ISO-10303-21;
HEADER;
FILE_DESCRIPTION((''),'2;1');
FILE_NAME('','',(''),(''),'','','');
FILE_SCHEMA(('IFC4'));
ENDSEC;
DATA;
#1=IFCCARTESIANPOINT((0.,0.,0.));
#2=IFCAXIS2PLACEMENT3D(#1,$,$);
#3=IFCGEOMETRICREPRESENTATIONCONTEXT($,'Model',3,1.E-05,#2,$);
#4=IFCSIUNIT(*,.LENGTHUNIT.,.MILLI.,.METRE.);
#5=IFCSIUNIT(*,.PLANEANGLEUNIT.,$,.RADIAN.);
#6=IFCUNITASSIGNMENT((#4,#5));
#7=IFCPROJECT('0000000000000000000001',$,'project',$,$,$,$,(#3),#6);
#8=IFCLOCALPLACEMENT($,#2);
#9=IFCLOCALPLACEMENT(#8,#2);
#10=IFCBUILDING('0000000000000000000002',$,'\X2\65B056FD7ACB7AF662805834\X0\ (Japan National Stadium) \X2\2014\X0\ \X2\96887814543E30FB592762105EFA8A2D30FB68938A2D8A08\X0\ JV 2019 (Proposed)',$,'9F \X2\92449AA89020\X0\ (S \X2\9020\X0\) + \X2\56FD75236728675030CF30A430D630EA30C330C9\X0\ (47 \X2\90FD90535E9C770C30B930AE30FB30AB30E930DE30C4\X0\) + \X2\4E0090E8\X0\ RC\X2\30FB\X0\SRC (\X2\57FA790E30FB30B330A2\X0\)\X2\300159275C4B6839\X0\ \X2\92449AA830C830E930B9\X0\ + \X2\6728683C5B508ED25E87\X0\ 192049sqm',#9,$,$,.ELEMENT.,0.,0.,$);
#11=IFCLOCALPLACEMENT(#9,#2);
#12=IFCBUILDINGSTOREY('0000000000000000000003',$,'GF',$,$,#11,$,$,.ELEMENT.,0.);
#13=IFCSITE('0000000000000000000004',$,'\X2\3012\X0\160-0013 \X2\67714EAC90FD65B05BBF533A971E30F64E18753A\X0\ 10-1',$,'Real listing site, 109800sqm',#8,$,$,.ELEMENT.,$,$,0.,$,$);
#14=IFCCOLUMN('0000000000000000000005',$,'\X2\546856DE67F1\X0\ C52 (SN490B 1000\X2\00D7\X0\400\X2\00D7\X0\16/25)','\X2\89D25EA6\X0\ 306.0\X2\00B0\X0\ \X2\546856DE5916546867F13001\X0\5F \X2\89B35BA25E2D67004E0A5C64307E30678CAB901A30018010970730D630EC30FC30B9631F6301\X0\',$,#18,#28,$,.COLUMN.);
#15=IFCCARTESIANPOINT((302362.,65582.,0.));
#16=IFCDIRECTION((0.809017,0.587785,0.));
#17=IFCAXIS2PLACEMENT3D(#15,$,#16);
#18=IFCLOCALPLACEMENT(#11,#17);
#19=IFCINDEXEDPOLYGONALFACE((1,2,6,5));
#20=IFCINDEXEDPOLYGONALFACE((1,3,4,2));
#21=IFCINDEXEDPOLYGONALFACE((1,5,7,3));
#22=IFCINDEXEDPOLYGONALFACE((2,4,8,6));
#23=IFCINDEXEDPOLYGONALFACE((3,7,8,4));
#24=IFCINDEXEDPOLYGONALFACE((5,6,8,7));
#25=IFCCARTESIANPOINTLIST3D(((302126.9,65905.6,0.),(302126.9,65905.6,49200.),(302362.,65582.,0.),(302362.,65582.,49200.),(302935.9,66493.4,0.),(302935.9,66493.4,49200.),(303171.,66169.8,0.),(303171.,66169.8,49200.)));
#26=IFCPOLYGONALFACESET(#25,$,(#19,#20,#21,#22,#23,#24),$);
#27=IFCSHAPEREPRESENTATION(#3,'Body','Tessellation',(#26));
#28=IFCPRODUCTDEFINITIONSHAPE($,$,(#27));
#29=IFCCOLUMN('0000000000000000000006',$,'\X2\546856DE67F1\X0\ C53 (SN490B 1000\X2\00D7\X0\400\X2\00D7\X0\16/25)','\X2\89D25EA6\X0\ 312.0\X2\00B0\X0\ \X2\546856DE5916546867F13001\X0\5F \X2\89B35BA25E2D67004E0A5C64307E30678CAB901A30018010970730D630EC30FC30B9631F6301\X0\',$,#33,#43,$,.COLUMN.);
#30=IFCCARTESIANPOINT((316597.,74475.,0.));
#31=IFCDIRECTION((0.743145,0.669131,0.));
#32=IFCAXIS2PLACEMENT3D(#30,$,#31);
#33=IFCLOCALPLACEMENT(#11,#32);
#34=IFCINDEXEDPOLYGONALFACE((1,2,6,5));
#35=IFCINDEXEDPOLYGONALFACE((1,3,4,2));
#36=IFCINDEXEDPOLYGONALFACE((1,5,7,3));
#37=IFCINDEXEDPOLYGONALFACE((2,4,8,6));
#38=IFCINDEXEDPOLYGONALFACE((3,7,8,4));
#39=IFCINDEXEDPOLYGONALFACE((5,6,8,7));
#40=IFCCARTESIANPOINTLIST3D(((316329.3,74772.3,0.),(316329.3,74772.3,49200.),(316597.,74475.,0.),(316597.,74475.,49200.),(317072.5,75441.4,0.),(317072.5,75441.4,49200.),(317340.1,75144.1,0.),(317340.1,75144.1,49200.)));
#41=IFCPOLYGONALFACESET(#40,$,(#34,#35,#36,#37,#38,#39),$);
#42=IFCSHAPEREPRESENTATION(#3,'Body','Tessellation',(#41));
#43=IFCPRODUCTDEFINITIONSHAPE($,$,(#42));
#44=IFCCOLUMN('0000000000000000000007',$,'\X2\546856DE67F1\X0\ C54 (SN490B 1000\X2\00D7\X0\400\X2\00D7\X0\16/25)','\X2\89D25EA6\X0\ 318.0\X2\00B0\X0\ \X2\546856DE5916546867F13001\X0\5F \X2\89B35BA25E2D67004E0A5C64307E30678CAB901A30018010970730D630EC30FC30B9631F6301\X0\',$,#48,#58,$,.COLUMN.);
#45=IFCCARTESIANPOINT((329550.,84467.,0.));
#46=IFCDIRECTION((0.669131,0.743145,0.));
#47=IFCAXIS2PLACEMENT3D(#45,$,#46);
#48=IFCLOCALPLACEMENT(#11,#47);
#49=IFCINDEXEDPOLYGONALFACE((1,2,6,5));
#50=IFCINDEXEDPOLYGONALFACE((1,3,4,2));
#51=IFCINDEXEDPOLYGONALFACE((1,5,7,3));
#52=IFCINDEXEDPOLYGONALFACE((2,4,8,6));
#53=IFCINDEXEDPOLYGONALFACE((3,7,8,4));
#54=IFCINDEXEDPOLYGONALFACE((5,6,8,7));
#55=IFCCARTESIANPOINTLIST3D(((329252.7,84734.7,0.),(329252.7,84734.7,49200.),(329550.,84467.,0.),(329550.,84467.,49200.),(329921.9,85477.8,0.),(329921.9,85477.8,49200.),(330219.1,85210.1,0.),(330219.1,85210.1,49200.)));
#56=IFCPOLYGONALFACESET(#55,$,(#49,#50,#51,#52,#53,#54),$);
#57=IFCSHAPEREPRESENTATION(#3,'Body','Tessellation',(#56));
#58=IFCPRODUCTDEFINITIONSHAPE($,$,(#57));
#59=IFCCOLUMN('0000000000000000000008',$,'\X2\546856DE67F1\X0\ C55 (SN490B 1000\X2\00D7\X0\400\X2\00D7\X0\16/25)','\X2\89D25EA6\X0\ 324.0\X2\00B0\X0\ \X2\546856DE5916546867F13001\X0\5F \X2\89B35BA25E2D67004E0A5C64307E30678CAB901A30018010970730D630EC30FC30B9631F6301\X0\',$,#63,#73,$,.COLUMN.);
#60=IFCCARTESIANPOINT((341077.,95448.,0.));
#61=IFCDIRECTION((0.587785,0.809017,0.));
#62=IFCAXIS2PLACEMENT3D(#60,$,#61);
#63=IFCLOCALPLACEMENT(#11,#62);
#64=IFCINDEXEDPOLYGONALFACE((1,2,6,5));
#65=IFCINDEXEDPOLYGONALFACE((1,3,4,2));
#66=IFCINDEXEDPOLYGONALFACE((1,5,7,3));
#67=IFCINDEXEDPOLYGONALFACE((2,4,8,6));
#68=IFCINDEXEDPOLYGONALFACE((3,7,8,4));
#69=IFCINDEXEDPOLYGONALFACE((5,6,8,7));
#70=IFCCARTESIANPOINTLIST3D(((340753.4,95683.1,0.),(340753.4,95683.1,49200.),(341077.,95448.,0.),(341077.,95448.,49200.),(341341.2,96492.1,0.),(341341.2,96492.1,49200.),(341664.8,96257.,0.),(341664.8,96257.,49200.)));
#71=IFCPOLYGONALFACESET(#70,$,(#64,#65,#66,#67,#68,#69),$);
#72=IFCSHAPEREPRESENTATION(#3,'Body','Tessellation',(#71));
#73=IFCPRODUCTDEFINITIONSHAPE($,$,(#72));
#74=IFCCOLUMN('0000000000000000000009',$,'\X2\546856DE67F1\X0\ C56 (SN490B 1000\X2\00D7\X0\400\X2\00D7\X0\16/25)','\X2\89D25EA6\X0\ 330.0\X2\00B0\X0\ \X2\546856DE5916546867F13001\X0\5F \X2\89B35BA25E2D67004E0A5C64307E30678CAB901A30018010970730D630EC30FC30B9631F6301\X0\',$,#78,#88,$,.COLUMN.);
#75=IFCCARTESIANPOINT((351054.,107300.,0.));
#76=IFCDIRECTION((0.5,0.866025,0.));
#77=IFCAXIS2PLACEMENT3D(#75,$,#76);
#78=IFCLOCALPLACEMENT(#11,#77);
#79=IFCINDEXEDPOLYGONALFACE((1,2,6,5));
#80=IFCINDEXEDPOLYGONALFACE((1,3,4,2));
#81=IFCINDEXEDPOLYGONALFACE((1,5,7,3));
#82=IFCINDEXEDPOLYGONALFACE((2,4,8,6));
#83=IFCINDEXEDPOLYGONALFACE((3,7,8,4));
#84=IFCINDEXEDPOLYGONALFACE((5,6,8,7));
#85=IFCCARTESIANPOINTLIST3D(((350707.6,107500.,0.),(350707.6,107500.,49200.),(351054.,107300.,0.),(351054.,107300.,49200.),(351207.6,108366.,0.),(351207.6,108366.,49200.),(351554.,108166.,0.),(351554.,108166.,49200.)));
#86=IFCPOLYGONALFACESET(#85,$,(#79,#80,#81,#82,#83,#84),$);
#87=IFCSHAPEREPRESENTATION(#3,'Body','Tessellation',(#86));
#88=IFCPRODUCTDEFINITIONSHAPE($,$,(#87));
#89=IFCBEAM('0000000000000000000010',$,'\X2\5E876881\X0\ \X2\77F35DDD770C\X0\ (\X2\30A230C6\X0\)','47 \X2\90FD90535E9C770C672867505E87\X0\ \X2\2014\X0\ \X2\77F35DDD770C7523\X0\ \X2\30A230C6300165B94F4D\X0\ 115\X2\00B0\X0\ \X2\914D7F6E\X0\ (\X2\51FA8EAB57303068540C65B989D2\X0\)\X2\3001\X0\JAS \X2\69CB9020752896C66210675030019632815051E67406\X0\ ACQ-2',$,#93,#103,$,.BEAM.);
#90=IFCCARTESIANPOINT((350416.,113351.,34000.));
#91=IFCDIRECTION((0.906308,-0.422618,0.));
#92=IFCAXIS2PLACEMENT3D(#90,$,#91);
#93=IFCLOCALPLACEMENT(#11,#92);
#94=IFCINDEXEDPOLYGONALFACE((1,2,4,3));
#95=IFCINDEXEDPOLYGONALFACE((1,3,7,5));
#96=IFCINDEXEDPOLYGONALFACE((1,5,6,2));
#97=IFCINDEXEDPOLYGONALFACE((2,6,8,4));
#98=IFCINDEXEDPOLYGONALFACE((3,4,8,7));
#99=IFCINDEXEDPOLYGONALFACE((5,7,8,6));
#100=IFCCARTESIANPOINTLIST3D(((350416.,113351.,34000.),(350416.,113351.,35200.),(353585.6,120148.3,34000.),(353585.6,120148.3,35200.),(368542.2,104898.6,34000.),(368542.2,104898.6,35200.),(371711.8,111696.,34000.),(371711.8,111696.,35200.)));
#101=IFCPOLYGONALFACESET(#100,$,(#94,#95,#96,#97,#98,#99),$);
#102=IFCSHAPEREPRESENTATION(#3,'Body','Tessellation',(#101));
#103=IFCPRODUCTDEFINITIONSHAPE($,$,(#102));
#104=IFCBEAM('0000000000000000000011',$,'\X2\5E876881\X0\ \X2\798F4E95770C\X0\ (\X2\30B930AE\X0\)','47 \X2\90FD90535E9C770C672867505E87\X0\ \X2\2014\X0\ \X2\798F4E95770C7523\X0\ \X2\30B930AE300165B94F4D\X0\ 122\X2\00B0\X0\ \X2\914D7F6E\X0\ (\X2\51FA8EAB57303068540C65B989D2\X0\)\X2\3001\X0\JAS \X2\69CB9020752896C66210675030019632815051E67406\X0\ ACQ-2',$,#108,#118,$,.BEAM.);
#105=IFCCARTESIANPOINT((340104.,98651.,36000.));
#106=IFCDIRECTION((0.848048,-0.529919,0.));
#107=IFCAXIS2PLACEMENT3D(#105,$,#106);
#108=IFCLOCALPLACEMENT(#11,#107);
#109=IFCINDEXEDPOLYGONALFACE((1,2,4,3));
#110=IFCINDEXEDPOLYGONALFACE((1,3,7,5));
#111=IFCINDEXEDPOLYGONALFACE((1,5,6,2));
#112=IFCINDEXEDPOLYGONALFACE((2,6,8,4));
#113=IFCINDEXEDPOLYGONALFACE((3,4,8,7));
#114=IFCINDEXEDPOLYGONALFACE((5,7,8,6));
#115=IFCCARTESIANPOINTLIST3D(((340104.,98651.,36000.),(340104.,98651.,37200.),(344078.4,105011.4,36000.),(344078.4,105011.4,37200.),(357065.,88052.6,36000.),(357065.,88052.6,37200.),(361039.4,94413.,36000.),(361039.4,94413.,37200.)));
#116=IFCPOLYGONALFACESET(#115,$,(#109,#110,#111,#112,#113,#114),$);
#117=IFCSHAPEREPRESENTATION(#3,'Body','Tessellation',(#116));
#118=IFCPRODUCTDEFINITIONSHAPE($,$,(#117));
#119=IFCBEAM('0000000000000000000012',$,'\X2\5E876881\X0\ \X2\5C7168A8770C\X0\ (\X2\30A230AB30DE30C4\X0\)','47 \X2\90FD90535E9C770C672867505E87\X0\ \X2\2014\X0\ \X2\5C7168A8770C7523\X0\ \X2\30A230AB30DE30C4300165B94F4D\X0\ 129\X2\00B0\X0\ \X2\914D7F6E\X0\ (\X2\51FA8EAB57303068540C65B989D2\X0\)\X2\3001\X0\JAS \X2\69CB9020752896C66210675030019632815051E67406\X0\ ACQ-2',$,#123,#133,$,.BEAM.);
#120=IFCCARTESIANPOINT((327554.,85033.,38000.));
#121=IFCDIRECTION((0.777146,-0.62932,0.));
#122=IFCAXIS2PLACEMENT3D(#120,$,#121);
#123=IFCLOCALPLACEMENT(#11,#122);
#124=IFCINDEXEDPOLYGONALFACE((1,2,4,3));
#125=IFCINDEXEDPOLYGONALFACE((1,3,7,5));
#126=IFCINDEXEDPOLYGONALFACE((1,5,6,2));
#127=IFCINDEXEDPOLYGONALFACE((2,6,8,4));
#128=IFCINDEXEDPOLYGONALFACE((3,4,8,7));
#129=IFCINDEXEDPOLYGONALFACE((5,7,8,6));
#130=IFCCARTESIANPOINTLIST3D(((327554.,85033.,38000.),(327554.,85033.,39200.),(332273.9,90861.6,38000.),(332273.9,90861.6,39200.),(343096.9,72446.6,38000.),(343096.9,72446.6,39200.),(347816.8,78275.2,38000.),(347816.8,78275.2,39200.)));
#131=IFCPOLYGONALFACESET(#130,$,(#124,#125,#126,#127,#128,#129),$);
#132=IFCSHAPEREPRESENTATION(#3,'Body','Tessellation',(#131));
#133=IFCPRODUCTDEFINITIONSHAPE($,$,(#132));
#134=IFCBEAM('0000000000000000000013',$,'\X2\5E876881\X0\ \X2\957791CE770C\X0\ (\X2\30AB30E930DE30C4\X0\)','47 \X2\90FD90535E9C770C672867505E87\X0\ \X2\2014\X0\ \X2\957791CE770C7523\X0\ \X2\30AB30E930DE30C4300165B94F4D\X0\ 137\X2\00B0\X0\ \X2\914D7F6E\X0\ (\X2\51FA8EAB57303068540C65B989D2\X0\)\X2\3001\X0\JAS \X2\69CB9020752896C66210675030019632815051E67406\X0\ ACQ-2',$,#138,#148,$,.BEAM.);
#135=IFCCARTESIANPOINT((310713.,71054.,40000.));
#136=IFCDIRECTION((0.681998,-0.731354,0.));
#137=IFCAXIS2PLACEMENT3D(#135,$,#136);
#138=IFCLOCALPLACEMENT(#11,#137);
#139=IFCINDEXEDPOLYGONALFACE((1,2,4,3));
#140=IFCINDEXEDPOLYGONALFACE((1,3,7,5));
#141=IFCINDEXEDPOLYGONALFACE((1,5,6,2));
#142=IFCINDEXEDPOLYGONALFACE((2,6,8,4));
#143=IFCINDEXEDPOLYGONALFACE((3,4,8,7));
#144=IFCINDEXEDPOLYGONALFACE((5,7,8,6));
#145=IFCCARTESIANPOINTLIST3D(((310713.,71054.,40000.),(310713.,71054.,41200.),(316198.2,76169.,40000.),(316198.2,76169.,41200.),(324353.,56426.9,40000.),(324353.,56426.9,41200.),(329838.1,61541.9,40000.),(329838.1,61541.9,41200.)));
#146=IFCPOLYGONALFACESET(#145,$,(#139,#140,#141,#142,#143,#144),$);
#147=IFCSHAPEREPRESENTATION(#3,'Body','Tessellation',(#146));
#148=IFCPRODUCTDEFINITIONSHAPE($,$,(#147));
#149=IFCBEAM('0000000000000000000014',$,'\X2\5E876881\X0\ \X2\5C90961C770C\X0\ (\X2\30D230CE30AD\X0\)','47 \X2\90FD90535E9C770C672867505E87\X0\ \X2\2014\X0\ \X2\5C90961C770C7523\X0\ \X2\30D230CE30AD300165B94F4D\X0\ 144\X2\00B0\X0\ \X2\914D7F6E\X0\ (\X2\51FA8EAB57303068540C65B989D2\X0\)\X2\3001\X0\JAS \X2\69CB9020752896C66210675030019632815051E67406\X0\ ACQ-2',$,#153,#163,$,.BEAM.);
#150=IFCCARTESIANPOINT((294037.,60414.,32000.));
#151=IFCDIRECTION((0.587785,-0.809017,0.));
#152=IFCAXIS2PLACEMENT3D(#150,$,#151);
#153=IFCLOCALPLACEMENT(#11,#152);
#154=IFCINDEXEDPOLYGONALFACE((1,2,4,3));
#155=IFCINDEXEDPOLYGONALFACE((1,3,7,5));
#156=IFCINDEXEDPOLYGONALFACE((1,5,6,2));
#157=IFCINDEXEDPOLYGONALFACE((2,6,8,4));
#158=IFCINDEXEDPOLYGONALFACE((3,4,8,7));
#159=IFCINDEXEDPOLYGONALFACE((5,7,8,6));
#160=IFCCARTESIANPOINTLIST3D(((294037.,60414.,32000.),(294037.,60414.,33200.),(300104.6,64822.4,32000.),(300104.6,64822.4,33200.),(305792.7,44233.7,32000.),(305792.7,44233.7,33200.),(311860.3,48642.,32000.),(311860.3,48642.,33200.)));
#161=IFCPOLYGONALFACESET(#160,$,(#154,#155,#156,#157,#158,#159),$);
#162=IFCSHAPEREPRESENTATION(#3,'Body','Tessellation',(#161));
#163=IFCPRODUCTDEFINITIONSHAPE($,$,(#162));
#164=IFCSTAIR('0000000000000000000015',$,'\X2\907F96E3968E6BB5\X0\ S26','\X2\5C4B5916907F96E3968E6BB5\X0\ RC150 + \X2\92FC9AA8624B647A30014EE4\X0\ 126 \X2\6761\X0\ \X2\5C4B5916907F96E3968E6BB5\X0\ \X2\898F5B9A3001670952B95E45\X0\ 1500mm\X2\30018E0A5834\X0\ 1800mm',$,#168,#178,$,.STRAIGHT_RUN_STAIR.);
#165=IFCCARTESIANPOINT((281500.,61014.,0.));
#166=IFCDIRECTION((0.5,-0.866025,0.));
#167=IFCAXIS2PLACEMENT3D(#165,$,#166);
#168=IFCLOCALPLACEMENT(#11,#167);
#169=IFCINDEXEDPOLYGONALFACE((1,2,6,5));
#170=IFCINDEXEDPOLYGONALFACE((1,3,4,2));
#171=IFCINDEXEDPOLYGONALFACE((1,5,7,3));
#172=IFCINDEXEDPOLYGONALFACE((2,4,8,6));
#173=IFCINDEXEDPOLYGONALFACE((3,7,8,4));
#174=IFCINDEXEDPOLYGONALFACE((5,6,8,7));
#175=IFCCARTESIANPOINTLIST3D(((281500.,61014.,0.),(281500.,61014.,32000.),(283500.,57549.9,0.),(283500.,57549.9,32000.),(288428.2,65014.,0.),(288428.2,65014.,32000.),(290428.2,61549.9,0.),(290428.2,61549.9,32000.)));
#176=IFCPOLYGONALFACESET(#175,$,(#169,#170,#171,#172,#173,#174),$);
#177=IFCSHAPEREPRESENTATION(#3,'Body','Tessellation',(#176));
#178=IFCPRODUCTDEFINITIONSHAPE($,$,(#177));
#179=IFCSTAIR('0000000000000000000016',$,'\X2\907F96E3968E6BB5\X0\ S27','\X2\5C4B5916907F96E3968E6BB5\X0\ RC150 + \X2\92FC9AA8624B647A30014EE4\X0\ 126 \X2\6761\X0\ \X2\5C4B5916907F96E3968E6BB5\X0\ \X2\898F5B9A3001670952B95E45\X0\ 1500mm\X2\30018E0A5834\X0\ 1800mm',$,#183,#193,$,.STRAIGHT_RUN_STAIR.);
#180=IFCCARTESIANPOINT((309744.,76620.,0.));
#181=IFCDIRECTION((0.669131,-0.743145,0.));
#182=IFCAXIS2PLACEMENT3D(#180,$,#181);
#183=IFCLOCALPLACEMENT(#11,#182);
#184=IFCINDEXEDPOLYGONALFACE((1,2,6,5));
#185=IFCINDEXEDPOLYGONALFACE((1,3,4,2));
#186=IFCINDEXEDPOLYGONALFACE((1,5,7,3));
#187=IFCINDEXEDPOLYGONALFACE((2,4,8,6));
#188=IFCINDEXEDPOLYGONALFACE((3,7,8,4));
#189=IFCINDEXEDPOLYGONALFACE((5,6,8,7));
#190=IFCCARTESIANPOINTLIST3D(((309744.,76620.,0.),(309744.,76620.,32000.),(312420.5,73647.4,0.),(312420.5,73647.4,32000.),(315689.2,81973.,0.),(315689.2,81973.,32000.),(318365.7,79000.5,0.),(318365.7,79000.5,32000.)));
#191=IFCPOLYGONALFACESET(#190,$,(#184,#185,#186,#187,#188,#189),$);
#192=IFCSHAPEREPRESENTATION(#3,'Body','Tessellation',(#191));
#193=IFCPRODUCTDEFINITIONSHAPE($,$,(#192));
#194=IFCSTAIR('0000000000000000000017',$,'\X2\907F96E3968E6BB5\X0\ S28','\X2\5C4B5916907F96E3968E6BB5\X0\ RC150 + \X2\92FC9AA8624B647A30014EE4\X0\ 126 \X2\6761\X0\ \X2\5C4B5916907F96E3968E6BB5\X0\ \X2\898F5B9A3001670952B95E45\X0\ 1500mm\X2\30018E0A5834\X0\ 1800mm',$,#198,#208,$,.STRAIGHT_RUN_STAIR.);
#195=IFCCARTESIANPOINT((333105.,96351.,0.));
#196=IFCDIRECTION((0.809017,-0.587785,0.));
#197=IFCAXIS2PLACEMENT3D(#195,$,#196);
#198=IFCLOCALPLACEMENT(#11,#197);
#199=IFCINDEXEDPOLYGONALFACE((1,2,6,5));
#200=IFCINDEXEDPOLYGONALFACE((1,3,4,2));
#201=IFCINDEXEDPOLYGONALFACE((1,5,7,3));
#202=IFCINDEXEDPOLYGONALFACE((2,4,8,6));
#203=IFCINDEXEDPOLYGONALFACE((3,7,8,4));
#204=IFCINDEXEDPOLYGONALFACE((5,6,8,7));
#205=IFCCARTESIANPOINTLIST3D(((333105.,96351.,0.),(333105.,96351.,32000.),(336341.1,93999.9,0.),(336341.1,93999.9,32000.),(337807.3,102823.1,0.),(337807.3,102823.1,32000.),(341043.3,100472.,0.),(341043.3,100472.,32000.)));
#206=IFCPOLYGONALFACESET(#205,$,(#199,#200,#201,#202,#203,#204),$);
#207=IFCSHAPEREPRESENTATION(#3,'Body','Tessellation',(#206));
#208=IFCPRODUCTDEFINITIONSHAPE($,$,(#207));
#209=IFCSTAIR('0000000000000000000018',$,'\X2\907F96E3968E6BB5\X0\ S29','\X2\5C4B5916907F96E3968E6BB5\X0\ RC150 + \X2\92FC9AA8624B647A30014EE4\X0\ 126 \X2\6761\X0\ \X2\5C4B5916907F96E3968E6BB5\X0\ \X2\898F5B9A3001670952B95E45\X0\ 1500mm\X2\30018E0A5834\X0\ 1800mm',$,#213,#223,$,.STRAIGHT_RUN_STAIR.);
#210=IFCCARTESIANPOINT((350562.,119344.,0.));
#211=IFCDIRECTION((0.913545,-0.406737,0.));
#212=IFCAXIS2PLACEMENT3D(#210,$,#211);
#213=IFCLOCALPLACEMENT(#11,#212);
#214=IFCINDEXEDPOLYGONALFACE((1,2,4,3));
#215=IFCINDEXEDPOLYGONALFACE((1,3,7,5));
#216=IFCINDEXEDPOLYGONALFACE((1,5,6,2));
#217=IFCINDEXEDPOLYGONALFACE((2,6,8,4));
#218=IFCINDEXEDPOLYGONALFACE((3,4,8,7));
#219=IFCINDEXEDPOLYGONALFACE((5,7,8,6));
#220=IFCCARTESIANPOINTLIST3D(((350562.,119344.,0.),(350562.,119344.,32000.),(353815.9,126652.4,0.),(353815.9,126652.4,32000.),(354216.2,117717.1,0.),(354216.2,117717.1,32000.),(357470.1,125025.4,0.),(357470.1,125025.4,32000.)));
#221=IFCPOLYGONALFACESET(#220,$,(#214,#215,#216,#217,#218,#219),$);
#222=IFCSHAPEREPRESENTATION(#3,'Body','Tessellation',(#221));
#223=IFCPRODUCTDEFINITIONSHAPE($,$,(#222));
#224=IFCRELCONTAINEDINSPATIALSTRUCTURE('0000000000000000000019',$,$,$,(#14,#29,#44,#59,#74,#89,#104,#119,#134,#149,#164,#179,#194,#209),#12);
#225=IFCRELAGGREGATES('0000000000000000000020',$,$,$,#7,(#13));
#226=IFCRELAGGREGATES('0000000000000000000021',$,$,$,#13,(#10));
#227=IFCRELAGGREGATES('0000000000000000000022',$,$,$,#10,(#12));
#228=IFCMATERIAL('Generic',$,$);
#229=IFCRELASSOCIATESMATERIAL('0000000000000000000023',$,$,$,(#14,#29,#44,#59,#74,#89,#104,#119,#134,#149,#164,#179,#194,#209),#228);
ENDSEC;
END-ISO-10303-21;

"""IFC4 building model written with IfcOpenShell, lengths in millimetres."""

from ifc_helpers import new_model, si_unit, frame, frame_2d, origin, place, context, project, spatial, rectangle, extrude, material, element, save


model = new_model("IFC4")

# Units and contexts
model_context = context("Model", 3, precision=1e-05, world=origin())
ifc_project = project(units=[si_unit("LENGTHUNIT", "METRE", prefix="MILLI"), si_unit("PLANEANGLEUNIT", "RADIAN")], contexts=[model_context])

# Site, building, storey
site_placement = place(None, origin())
site = spatial("IfcSite", under=ifc_project, at=site_placement, Name="〒160-0013 東京都新宿区霞ヶ丘町 10-1", ObjectType="Real listing site, 109800sqm", CompositionType="ELEMENT", RefElevation=0.0)
building_placement = place(site_placement, origin())
building = spatial("IfcBuilding", under=site, at=building_placement, Name="新国立競技場 (Japan National Stadium) — 隈研吾・大成建設・梓設計 JV 2019 (Proposed)", ObjectType="9F 鉄骨造 (S 造) + 国産木材ハイブリッド (47 都道府県スギ・カラマツ) + 一部 RC・SRC (基礎・コア)、大屋根 鉄骨トラス + 木格子軒庇 192049sqm", CompositionType="ELEMENT", ElevationOfRefHeight=0.0, ElevationOfTerrain=0.0)
storey_placement = place(building_placement, origin())
storey = spatial("IfcBuildingStorey", under=building, at=storey_placement, Name="GF", CompositionType="ELEMENT", Elevation=0.0)

# Columns
ifc_material_1 = material(Name="Generic")
column_1_placement = place(storey_placement, frame((302362.0, 65582.0, 0.0), x_axis=(0.809017, 0.587785, 0.0)))
element("IfcColumn", 1, at=column_1_placement, inside=storey, material=ifc_material_1, Name="周回柱 C52 (SN490B 1000×400×16/25)", Description="角度 306.0° 周回外周柱、5F 観客席最上層まで貫通、耐震ブレース挟持", PredefinedType="COLUMN", context=model_context, shape_type="SweptSolid", body=[
    extrude(rectangle(XDim=1000.0, YDim=400.0, at=frame_2d((500.0, 200.0))), frame((302362.0, 65582.0, 0.0), x_axis=(0.809017, 0.587785, 0.0)), (0.0, 0.0, 1.0), 49200.0),
])
column_2_placement = place(storey_placement, frame((316597.0, 74475.0, 0.0), x_axis=(0.743145, 0.669131, 0.0)))
element("IfcColumn", 2, at=column_2_placement, inside=storey, material=ifc_material_1, Name="周回柱 C53 (SN490B 1000×400×16/25)", Description="角度 312.0° 周回外周柱、5F 観客席最上層まで貫通、耐震ブレース挟持", PredefinedType="COLUMN", context=model_context, shape_type="SweptSolid", body=[
    extrude(rectangle(XDim=1000.0, YDim=400.0, at=frame_2d((500.0, 200.0))), frame((316597.0, 74475.0, 0.0), x_axis=(0.743145, 0.669131, 0.0)), (0.0, 0.0, 1.0), 49200.0),
])
column_3_placement = place(storey_placement, frame((329550.0, 84467.0, 0.0), x_axis=(0.669131, 0.743145, 0.0)))
element("IfcColumn", 3, at=column_3_placement, inside=storey, material=ifc_material_1, Name="周回柱 C54 (SN490B 1000×400×16/25)", Description="角度 318.0° 周回外周柱、5F 観客席最上層まで貫通、耐震ブレース挟持", PredefinedType="COLUMN", context=model_context, shape_type="SweptSolid", body=[
    extrude(rectangle(XDim=1000.0, YDim=400.0, at=frame_2d((500.0, 200.0))), frame((329550.0, 84467.0, 0.0), x_axis=(0.669131, 0.743145, 0.0)), (0.0, 0.0, 1.0), 49200.0),
])
column_4_placement = place(storey_placement, frame((341077.0, 95448.0, 0.0), x_axis=(0.587785, 0.809017, 0.0)))
element("IfcColumn", 4, at=column_4_placement, inside=storey, material=ifc_material_1, Name="周回柱 C55 (SN490B 1000×400×16/25)", Description="角度 324.0° 周回外周柱、5F 観客席最上層まで貫通、耐震ブレース挟持", PredefinedType="COLUMN", context=model_context, shape_type="SweptSolid", body=[
    extrude(rectangle(XDim=1000.0, YDim=400.0, at=frame_2d((500.0, 200.0))), frame((341077.0, 95448.0, 0.0), x_axis=(0.587785, 0.809017, 0.0)), (0.0, 0.0, 1.0), 49200.0),
])
column_5_placement = place(storey_placement, frame((351054.0, 107300.0, 0.0), x_axis=(0.5, 0.866025, 0.0)))
element("IfcColumn", 5, at=column_5_placement, inside=storey, material=ifc_material_1, Name="周回柱 C56 (SN490B 1000×400×16/25)", Description="角度 330.0° 周回外周柱、5F 観客席最上層まで貫通、耐震ブレース挟持", PredefinedType="COLUMN", context=model_context, shape_type="SweptSolid", body=[
    extrude(rectangle(XDim=1000.0, YDim=400.0, at=frame_2d((500.0, 200.0))), frame((351054.0, 107300.0, 0.0), x_axis=(0.5, 0.866025, 0.0)), (0.0, 0.0, 1.0), 49200.0),
])

# Beams
beam_1_placement = place(storey_placement, frame((350416.0, 113351.0, 34000.0), x_axis=(0.906308, -0.422618, 0.0)))
element("IfcBeam", 6, at=beam_1_placement, inside=storey, material=ifc_material_1, Name="庇梁 石川県 (アテ)", Description="47 都道府県木材庇 — 石川県産 アテ、方位 115° 配置 (出身地と同方角)、JAS 構造用集成材、防腐処理 ACQ-2", PredefinedType="BEAM", context=model_context, shape_type="SweptSolid", body=[
    extrude(rectangle(XDim=20000.0, YDim=7500.0, at=frame_2d((10000.0, 3750.0))), frame((350416.0, 113351.0, 34000.0), x_axis=(0.906308, -0.422618, 0.0)), (0.0, 0.0, 1.0), 1200.0),
])
beam_2_placement = place(storey_placement, frame((340104.0, 98651.0, 36000.0), x_axis=(0.848048, -0.529919, 0.0)))
element("IfcBeam", 7, at=beam_2_placement, inside=storey, material=ifc_material_1, Name="庇梁 福井県 (スギ)", Description="47 都道府県木材庇 — 福井県産 スギ、方位 122° 配置 (出身地と同方角)、JAS 構造用集成材、防腐処理 ACQ-2", PredefinedType="BEAM", context=model_context, shape_type="SweptSolid", body=[
    extrude(rectangle(XDim=20000.0, YDim=7500.0, at=frame_2d((10000.0, 3750.0))), frame((340104.0, 98651.0, 36000.0), x_axis=(0.848048, -0.529919, 0.0)), (0.0, 0.0, 1.0), 1200.0),
])
beam_3_placement = place(storey_placement, frame((327554.0, 85033.0, 38000.0), x_axis=(0.777146, -0.62932, 0.0)))
element("IfcBeam", 8, at=beam_3_placement, inside=storey, material=ifc_material_1, Name="庇梁 山梨県 (アカマツ)", Description="47 都道府県木材庇 — 山梨県産 アカマツ、方位 129° 配置 (出身地と同方角)、JAS 構造用集成材、防腐処理 ACQ-2", PredefinedType="BEAM", context=model_context, shape_type="SweptSolid", body=[
    extrude(rectangle(XDim=20000.0, YDim=7500.0, at=frame_2d((10000.0, 3750.0))), frame((327554.0, 85033.0, 38000.0), x_axis=(0.777146, -0.62932, 0.0)), (0.0, 0.0, 1.0), 1200.0),
])
beam_4_placement = place(storey_placement, frame((310713.0, 71054.0, 40000.0), x_axis=(0.681998, -0.731354, 0.0)))
element("IfcBeam", 9, at=beam_4_placement, inside=storey, material=ifc_material_1, Name="庇梁 長野県 (カラマツ)", Description="47 都道府県木材庇 — 長野県産 カラマツ、方位 137° 配置 (出身地と同方角)、JAS 構造用集成材、防腐処理 ACQ-2", PredefinedType="BEAM", context=model_context, shape_type="SweptSolid", body=[
    extrude(rectangle(XDim=20000.0, YDim=7500.0, at=frame_2d((10000.0, 3750.0))), frame((310713.0, 71054.0, 40000.0), x_axis=(0.681998, -0.731354, 0.0)), (0.0, 0.0, 1.0), 1200.0),
])
beam_5_placement = place(storey_placement, frame((294037.0, 60414.0, 32000.0), x_axis=(0.587785, -0.809017, 0.0)))
element("IfcBeam", 10, at=beam_5_placement, inside=storey, material=ifc_material_1, Name="庇梁 岐阜県 (ヒノキ)", Description="47 都道府県木材庇 — 岐阜県産 ヒノキ、方位 144° 配置 (出身地と同方角)、JAS 構造用集成材、防腐処理 ACQ-2", PredefinedType="BEAM", context=model_context, shape_type="SweptSolid", body=[
    extrude(rectangle(XDim=20000.0, YDim=7500.0, at=frame_2d((10000.0, 3750.0))), frame((294037.0, 60414.0, 32000.0), x_axis=(0.587785, -0.809017, 0.0)), (0.0, 0.0, 1.0), 1200.0),
])

# Stairs
stair_1_placement = place(storey_placement, frame((281500.0, 61014.0, 0.0), x_axis=(0.5, -0.866025, 0.0)))
element("IfcStair", 11, at=stair_1_placement, inside=storey, material=ifc_material_1, Name="避難階段 S26", Description="屋外避難階段 RC150 + 鋼骨手摺、令 126 条 屋外避難階段 規定、有効幅 1500mm、踊場 1800mm", PredefinedType="STRAIGHT_RUN_STAIR", context=model_context, shape_type="SweptSolid", body=[
    extrude(rectangle(XDim=4000.0, YDim=8000.0, at=frame_2d((2000.0, 4000.0))), frame((281500.0, 61014.0, 0.0), x_axis=(0.5, -0.866025, 0.0)), (0.0, 0.0, 1.0), 32000.0),
])
stair_2_placement = place(storey_placement, frame((309744.0, 76620.0, 0.0), x_axis=(0.669131, -0.743145, 0.0)))
element("IfcStair", 12, at=stair_2_placement, inside=storey, material=ifc_material_1, Name="避難階段 S27", Description="屋外避難階段 RC150 + 鋼骨手摺、令 126 条 屋外避難階段 規定、有効幅 1500mm、踊場 1800mm", PredefinedType="STRAIGHT_RUN_STAIR", context=model_context, shape_type="SweptSolid", body=[
    extrude(rectangle(XDim=4000.0, YDim=8000.0, at=frame_2d((2000.0, 4000.0))), frame((309744.0, 76620.0, 0.0), x_axis=(0.669131, -0.743145, 0.0)), (0.0, 0.0, 1.0), 32000.0),
])
stair_3_placement = place(storey_placement, frame((333105.0, 96351.0, 0.0), x_axis=(0.809017, -0.587785, 0.0)))
element("IfcStair", 13, at=stair_3_placement, inside=storey, material=ifc_material_1, Name="避難階段 S28", Description="屋外避難階段 RC150 + 鋼骨手摺、令 126 条 屋外避難階段 規定、有効幅 1500mm、踊場 1800mm", PredefinedType="STRAIGHT_RUN_STAIR", context=model_context, shape_type="SweptSolid", body=[
    extrude(rectangle(XDim=4000.0, YDim=8000.0, at=frame_2d((2000.0, 4000.0))), frame((333105.0, 96351.0, 0.0), x_axis=(0.809017, -0.587785, 0.0)), (0.0, 0.0, 1.0), 32000.0),
])
stair_4_placement = place(storey_placement, frame((350562.0, 119344.0, 0.0), x_axis=(0.913545, -0.406737, 0.0)))
element("IfcStair", 14, at=stair_4_placement, inside=storey, material=ifc_material_1, Name="避難階段 S29", Description="屋外避難階段 RC150 + 鋼骨手摺、令 126 条 屋外避難階段 規定、有効幅 1500mm、踊場 1800mm", PredefinedType="STRAIGHT_RUN_STAIR", context=model_context, shape_type="SweptSolid", body=[
    extrude(rectangle(XDim=4000.0, YDim=8000.0, at=frame_2d((2000.0, 4000.0))), frame((350562.0, 119344.0, 0.0), x_axis=(0.913545, -0.406737, 0.0)), (0.0, 0.0, 1.0), 32000.0),
])

save(model, "model.ifc")
